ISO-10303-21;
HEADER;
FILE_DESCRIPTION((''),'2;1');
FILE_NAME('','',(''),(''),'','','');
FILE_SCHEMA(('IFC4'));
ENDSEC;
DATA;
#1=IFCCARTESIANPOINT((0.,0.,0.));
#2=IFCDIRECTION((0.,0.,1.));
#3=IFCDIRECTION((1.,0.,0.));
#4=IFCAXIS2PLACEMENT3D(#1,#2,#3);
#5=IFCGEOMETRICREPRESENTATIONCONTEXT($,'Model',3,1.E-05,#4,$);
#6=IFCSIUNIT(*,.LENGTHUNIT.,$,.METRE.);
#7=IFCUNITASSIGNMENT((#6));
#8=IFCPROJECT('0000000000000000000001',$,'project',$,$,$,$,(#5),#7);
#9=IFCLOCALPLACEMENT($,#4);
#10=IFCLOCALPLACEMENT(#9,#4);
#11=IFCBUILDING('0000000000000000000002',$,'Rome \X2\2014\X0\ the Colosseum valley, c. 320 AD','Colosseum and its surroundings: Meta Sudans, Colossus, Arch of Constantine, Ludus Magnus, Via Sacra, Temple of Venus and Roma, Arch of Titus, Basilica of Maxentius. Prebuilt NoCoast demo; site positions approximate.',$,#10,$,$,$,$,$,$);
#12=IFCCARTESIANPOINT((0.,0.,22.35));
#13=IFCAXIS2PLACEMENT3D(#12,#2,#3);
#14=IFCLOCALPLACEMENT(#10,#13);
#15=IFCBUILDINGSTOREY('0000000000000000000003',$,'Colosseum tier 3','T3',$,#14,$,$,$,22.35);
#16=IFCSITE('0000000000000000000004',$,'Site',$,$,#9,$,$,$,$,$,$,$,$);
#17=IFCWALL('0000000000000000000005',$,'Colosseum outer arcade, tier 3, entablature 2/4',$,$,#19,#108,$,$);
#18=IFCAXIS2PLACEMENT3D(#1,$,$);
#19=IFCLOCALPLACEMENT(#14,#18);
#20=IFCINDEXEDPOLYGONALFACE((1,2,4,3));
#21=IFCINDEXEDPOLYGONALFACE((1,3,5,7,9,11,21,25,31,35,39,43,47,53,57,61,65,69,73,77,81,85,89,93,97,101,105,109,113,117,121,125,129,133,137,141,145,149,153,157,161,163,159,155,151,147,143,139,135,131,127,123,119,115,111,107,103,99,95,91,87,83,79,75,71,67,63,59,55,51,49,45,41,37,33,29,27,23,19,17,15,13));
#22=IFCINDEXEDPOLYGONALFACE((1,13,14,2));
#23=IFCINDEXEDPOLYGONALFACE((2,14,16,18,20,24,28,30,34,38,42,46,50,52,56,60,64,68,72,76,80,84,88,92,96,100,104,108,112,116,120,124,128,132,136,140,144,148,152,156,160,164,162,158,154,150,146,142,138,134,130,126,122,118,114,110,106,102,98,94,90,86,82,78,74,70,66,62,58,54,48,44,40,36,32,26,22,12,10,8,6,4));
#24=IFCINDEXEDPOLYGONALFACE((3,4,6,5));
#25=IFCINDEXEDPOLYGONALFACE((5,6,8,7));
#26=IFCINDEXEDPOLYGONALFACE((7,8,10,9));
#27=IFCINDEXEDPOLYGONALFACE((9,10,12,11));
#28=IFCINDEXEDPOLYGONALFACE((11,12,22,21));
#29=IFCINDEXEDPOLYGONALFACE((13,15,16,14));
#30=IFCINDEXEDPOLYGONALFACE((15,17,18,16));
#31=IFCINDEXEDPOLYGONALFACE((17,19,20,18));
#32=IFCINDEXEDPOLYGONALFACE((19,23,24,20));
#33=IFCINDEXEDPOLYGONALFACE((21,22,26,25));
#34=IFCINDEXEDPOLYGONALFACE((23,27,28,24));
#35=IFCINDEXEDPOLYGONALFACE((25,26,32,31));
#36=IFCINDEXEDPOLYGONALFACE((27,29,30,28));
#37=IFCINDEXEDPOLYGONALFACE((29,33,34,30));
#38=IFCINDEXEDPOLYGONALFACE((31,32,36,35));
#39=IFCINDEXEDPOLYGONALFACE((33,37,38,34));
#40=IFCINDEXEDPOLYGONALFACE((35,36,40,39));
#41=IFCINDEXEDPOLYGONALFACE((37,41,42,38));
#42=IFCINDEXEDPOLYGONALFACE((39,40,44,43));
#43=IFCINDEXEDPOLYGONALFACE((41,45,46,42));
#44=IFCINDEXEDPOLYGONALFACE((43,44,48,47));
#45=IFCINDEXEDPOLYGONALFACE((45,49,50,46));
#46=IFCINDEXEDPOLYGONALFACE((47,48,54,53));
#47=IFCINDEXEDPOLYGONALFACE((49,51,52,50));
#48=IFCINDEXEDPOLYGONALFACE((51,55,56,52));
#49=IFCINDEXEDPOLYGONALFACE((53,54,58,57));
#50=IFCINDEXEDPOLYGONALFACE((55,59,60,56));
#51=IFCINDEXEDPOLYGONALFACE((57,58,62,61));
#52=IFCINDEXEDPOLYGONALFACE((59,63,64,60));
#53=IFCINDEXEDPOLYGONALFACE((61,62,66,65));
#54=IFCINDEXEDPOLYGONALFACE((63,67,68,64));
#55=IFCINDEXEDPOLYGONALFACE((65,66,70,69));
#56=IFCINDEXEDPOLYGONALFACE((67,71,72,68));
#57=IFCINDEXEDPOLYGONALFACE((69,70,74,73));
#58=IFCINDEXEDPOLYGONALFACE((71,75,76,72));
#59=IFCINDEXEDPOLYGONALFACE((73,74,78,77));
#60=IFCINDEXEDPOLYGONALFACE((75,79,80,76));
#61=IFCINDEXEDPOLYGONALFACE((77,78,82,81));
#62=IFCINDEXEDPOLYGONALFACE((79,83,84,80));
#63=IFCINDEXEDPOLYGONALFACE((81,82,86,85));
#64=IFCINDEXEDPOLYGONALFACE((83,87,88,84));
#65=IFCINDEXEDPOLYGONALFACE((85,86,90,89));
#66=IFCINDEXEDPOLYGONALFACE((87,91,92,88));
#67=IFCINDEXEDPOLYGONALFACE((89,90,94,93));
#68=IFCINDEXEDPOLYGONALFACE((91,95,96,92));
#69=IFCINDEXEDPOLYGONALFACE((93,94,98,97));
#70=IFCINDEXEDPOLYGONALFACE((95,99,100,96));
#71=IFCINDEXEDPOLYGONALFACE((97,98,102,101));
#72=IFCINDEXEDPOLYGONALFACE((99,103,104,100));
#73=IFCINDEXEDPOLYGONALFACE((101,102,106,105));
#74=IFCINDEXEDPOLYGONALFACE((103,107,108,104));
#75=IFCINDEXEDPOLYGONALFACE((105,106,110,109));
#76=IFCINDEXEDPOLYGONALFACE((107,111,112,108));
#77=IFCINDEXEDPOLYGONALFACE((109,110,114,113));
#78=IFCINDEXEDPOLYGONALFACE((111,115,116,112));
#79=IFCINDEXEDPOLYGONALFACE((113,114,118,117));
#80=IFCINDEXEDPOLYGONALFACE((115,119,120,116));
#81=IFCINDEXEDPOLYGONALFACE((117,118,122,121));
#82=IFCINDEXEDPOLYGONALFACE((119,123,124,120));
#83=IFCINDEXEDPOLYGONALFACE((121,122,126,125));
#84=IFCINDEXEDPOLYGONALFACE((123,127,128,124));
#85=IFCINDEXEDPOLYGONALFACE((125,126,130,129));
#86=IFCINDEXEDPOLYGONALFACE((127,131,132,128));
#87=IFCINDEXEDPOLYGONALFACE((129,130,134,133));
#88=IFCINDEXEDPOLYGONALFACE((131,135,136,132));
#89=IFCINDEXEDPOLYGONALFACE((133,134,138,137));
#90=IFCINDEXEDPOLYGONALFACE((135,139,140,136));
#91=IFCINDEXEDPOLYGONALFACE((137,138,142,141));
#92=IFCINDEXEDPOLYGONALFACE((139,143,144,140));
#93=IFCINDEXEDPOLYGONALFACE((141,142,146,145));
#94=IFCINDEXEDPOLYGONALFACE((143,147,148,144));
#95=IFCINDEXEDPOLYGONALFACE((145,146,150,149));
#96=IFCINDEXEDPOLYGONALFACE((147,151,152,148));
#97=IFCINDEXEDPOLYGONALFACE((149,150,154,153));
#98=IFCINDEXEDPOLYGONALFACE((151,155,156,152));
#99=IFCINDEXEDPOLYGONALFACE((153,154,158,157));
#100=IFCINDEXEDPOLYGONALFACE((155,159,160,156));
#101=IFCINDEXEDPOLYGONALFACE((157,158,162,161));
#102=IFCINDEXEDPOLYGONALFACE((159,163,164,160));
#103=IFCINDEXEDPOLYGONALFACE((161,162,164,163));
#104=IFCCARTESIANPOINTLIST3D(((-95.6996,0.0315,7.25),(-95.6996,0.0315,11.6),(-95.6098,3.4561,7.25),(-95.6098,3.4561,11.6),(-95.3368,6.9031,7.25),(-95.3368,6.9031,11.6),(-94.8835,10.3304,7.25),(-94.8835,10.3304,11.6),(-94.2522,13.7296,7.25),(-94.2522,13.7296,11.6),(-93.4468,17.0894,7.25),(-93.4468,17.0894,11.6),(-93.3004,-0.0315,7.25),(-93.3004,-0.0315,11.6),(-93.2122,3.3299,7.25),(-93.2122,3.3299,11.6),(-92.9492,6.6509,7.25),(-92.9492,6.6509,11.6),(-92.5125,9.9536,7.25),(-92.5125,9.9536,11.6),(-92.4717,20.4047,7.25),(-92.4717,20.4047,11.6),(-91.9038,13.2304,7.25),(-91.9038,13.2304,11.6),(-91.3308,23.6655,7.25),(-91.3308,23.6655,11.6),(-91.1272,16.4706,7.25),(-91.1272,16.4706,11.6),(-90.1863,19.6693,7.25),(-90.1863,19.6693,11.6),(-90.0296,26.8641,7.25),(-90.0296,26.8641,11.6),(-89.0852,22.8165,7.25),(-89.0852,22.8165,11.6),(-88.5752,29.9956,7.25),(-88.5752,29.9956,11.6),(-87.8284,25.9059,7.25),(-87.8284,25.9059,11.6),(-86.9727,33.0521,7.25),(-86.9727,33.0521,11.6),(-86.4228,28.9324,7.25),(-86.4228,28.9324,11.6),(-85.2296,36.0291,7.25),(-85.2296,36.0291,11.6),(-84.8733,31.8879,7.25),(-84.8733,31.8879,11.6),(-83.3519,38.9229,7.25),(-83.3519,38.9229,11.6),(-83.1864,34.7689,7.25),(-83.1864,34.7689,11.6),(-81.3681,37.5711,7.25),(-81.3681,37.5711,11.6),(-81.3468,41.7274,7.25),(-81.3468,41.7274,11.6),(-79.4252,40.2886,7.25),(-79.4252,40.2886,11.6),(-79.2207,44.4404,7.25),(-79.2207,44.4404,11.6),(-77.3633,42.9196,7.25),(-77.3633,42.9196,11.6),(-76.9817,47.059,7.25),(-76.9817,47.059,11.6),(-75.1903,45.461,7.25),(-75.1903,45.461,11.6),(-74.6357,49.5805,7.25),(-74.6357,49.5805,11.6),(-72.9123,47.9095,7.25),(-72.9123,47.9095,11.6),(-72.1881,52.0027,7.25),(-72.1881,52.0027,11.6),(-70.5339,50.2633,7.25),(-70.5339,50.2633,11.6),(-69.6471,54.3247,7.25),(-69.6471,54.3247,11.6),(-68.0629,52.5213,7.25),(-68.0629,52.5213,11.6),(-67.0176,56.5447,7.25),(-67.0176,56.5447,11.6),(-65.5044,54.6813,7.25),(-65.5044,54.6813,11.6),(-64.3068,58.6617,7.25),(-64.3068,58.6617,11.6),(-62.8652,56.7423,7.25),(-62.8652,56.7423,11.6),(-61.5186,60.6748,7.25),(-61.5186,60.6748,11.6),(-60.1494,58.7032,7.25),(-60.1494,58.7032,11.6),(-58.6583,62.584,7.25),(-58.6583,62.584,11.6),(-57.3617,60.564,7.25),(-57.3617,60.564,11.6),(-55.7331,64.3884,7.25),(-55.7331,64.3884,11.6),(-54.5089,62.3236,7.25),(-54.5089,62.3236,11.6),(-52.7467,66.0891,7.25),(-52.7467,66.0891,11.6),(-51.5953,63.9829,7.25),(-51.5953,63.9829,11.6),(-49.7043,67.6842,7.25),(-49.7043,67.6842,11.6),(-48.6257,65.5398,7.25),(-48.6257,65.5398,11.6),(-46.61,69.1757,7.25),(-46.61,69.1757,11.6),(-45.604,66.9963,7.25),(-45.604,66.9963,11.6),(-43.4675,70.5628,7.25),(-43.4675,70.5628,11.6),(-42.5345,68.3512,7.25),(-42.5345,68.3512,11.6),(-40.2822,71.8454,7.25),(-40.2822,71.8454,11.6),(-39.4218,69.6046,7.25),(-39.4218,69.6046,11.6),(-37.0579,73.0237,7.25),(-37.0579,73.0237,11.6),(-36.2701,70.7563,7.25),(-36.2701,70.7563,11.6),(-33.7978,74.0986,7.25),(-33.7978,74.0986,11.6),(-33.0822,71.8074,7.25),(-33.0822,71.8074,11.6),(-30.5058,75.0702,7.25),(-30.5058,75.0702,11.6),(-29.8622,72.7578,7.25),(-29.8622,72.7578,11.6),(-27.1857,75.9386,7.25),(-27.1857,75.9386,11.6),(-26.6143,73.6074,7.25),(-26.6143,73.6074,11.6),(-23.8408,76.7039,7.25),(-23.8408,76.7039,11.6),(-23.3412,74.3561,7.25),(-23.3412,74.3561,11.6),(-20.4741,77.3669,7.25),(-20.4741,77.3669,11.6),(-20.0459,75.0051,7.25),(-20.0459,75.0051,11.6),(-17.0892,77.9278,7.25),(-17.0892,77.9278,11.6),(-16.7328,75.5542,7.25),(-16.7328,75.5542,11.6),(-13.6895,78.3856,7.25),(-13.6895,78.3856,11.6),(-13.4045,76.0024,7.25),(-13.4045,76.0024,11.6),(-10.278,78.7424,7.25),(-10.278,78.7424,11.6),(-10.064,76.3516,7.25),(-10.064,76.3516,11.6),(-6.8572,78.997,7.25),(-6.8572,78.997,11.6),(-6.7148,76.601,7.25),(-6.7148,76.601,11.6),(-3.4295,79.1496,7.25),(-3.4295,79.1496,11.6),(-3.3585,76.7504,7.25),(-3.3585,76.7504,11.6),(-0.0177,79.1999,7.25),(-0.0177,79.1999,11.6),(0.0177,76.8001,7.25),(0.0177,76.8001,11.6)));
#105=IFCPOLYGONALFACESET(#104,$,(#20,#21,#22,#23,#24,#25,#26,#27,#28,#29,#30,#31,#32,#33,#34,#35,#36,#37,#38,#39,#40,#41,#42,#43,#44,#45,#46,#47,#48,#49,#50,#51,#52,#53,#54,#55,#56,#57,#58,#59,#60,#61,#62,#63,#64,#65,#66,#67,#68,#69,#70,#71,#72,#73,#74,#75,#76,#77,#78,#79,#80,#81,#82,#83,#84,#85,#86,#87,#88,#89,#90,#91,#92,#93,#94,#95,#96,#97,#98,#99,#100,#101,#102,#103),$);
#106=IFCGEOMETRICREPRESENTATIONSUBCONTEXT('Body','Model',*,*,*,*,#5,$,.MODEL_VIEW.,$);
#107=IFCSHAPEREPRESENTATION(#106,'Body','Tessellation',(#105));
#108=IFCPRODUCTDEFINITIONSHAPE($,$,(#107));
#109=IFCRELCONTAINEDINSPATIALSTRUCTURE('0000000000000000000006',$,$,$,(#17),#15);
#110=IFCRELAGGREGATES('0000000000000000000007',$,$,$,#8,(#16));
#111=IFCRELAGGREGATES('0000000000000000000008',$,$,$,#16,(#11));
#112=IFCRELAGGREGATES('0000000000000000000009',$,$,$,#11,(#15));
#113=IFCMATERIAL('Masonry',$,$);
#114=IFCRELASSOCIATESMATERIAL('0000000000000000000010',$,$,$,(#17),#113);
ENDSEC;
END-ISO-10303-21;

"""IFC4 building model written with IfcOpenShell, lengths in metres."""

from ifc_helpers import new_model, si_unit, frame, origin_with_axes, place, context, subcontext, project, spatial, polyline, outline, extrude, material, element, save


model = new_model("IFC4")

# Units and contexts
model_context = context("Model", 3, precision=1e-05, world=origin_with_axes())
body_context = subcontext(model_context, "Body", "Model", "MODEL_VIEW")
ifc_project = project(units=[si_unit("LENGTHUNIT", "METRE")], contexts=[model_context])

# Site, building, storey
site_placement = place(None, origin_with_axes())
site = spatial("IfcSite", under=ifc_project, at=site_placement, Name="Site")
building_placement = place(site_placement, origin_with_axes())
building = spatial("IfcBuilding", under=site, at=building_placement, Name="Rome — the Colosseum valley, c. 320 AD", Description="Colosseum and its surroundings: Meta Sudans, Colossus, Arch of Constantine, Ludus Magnus, Via Sacra, Temple of Venus and Roma, Arch of Titus, Basilica of Maxentius. Prebuilt NoCoast demo; site positions approximate.")
storey_placement = place(building_placement, frame((0.0, 0.0, 22.35), z_axis=(0.0, 0.0, 1.0), x_axis=(1.0, 0.0, 0.0)))
storey = spatial("IfcBuildingStorey", under=building, at=storey_placement, Name="Colosseum tier 3", Description="T3", Elevation=22.35)

# Wall
ifc_material_1 = material(Name="Masonry")
wall_1_placement = place(storey_placement, frame((0.0, 0.0, 7.25), z_axis=(0.0, 0.0, 1.0), x_axis=(1.0, 0.0, 0.0)))
element("IfcWall", 1, at=wall_1_placement, inside=storey, material=ifc_material_1, Name="Colosseum outer arcade, tier 3, entablature 2/4", context=body_context, shape_type="SweptSolid", body=[
    extrude(outline(polyline([(-3.3585, 76.7504), (-6.7148, 76.601), (-10.064, 76.3516), (-13.4045, 76.0024), (-16.7328, 75.5542), (-20.0459, 75.0051), (-23.3412, 74.3561), (-26.6143, 73.6074), (-29.8622, 72.7578), (-33.0822, 71.8074), (-36.2701, 70.7563), (-39.4218, 69.6046), (-42.5345, 68.3512), (-45.604, 66.9963), (-48.6257, 65.5398), (-51.5953, 63.9829), (-54.5089, 62.3236), (-57.3617, 60.564), (-60.1494, 58.7032), (-62.8652, 56.7423), (-65.5044, 54.6813), (-68.0629, 52.5213), (-70.5339, 50.2633), (-72.9123, 47.9095), (-75.1903, 45.461), (-77.3633, 42.9196), (-79.4252, 40.2886), (-81.3681, 37.5711), (-83.1864, 34.7689), (-84.8733, 31.8879), (-86.4228, 28.9324), (-87.8284, 25.9059), (-89.0852, 22.8165), (-90.1863, 19.6693), (-91.1272, 16.4706), (-91.9038, 13.2304), (-92.5125, 9.9536), (-92.9492, 6.6509), (-93.2122, 3.3299), (-93.3004, -0.0315), (-95.6996, 0.0315), (-95.6098, 3.4561), (-95.3368, 6.9031), (-94.8835, 10.3304), (-94.2522, 13.7296), (-93.4468, 17.0894), (-92.4717, 20.4047), (-91.3308, 23.6655), (-90.0296, 26.8641), (-88.5752, 29.9956), (-86.9727, 33.0521), (-85.2296, 36.0291), (-83.3519, 38.9229), (-81.3468, 41.7274), (-79.2207, 44.4404), (-76.9817, 47.059), (-74.6357, 49.5805), (-72.1881, 52.0027), (-69.6471, 54.3247), (-67.0176, 56.5447), (-64.3068, 58.6617), (-61.5186, 60.6748), (-58.6583, 62.584), (-55.7331, 64.3884), (-52.7467, 66.0891), (-49.7043, 67.6842), (-46.61, 69.1757), (-43.4675, 70.5628), (-40.2822, 71.8454), (-37.0579, 73.0237), (-33.7978, 74.0986), (-30.5058, 75.0702), (-27.1857, 75.9386), (-23.8408, 76.7039), (-20.4741, 77.3669), (-17.0892, 77.9278), (-13.6895, 78.3856), (-10.278, 78.7424), (-6.8572, 78.997), (-3.4295, 79.1496), (-0.0177, 79.1999), (0.0177, 76.8001), (-3.3585, 76.7504)])), origin_with_axes(), (0.0, 0.0, 1.0), 4.35),
])

save(model, "model.ifc")
